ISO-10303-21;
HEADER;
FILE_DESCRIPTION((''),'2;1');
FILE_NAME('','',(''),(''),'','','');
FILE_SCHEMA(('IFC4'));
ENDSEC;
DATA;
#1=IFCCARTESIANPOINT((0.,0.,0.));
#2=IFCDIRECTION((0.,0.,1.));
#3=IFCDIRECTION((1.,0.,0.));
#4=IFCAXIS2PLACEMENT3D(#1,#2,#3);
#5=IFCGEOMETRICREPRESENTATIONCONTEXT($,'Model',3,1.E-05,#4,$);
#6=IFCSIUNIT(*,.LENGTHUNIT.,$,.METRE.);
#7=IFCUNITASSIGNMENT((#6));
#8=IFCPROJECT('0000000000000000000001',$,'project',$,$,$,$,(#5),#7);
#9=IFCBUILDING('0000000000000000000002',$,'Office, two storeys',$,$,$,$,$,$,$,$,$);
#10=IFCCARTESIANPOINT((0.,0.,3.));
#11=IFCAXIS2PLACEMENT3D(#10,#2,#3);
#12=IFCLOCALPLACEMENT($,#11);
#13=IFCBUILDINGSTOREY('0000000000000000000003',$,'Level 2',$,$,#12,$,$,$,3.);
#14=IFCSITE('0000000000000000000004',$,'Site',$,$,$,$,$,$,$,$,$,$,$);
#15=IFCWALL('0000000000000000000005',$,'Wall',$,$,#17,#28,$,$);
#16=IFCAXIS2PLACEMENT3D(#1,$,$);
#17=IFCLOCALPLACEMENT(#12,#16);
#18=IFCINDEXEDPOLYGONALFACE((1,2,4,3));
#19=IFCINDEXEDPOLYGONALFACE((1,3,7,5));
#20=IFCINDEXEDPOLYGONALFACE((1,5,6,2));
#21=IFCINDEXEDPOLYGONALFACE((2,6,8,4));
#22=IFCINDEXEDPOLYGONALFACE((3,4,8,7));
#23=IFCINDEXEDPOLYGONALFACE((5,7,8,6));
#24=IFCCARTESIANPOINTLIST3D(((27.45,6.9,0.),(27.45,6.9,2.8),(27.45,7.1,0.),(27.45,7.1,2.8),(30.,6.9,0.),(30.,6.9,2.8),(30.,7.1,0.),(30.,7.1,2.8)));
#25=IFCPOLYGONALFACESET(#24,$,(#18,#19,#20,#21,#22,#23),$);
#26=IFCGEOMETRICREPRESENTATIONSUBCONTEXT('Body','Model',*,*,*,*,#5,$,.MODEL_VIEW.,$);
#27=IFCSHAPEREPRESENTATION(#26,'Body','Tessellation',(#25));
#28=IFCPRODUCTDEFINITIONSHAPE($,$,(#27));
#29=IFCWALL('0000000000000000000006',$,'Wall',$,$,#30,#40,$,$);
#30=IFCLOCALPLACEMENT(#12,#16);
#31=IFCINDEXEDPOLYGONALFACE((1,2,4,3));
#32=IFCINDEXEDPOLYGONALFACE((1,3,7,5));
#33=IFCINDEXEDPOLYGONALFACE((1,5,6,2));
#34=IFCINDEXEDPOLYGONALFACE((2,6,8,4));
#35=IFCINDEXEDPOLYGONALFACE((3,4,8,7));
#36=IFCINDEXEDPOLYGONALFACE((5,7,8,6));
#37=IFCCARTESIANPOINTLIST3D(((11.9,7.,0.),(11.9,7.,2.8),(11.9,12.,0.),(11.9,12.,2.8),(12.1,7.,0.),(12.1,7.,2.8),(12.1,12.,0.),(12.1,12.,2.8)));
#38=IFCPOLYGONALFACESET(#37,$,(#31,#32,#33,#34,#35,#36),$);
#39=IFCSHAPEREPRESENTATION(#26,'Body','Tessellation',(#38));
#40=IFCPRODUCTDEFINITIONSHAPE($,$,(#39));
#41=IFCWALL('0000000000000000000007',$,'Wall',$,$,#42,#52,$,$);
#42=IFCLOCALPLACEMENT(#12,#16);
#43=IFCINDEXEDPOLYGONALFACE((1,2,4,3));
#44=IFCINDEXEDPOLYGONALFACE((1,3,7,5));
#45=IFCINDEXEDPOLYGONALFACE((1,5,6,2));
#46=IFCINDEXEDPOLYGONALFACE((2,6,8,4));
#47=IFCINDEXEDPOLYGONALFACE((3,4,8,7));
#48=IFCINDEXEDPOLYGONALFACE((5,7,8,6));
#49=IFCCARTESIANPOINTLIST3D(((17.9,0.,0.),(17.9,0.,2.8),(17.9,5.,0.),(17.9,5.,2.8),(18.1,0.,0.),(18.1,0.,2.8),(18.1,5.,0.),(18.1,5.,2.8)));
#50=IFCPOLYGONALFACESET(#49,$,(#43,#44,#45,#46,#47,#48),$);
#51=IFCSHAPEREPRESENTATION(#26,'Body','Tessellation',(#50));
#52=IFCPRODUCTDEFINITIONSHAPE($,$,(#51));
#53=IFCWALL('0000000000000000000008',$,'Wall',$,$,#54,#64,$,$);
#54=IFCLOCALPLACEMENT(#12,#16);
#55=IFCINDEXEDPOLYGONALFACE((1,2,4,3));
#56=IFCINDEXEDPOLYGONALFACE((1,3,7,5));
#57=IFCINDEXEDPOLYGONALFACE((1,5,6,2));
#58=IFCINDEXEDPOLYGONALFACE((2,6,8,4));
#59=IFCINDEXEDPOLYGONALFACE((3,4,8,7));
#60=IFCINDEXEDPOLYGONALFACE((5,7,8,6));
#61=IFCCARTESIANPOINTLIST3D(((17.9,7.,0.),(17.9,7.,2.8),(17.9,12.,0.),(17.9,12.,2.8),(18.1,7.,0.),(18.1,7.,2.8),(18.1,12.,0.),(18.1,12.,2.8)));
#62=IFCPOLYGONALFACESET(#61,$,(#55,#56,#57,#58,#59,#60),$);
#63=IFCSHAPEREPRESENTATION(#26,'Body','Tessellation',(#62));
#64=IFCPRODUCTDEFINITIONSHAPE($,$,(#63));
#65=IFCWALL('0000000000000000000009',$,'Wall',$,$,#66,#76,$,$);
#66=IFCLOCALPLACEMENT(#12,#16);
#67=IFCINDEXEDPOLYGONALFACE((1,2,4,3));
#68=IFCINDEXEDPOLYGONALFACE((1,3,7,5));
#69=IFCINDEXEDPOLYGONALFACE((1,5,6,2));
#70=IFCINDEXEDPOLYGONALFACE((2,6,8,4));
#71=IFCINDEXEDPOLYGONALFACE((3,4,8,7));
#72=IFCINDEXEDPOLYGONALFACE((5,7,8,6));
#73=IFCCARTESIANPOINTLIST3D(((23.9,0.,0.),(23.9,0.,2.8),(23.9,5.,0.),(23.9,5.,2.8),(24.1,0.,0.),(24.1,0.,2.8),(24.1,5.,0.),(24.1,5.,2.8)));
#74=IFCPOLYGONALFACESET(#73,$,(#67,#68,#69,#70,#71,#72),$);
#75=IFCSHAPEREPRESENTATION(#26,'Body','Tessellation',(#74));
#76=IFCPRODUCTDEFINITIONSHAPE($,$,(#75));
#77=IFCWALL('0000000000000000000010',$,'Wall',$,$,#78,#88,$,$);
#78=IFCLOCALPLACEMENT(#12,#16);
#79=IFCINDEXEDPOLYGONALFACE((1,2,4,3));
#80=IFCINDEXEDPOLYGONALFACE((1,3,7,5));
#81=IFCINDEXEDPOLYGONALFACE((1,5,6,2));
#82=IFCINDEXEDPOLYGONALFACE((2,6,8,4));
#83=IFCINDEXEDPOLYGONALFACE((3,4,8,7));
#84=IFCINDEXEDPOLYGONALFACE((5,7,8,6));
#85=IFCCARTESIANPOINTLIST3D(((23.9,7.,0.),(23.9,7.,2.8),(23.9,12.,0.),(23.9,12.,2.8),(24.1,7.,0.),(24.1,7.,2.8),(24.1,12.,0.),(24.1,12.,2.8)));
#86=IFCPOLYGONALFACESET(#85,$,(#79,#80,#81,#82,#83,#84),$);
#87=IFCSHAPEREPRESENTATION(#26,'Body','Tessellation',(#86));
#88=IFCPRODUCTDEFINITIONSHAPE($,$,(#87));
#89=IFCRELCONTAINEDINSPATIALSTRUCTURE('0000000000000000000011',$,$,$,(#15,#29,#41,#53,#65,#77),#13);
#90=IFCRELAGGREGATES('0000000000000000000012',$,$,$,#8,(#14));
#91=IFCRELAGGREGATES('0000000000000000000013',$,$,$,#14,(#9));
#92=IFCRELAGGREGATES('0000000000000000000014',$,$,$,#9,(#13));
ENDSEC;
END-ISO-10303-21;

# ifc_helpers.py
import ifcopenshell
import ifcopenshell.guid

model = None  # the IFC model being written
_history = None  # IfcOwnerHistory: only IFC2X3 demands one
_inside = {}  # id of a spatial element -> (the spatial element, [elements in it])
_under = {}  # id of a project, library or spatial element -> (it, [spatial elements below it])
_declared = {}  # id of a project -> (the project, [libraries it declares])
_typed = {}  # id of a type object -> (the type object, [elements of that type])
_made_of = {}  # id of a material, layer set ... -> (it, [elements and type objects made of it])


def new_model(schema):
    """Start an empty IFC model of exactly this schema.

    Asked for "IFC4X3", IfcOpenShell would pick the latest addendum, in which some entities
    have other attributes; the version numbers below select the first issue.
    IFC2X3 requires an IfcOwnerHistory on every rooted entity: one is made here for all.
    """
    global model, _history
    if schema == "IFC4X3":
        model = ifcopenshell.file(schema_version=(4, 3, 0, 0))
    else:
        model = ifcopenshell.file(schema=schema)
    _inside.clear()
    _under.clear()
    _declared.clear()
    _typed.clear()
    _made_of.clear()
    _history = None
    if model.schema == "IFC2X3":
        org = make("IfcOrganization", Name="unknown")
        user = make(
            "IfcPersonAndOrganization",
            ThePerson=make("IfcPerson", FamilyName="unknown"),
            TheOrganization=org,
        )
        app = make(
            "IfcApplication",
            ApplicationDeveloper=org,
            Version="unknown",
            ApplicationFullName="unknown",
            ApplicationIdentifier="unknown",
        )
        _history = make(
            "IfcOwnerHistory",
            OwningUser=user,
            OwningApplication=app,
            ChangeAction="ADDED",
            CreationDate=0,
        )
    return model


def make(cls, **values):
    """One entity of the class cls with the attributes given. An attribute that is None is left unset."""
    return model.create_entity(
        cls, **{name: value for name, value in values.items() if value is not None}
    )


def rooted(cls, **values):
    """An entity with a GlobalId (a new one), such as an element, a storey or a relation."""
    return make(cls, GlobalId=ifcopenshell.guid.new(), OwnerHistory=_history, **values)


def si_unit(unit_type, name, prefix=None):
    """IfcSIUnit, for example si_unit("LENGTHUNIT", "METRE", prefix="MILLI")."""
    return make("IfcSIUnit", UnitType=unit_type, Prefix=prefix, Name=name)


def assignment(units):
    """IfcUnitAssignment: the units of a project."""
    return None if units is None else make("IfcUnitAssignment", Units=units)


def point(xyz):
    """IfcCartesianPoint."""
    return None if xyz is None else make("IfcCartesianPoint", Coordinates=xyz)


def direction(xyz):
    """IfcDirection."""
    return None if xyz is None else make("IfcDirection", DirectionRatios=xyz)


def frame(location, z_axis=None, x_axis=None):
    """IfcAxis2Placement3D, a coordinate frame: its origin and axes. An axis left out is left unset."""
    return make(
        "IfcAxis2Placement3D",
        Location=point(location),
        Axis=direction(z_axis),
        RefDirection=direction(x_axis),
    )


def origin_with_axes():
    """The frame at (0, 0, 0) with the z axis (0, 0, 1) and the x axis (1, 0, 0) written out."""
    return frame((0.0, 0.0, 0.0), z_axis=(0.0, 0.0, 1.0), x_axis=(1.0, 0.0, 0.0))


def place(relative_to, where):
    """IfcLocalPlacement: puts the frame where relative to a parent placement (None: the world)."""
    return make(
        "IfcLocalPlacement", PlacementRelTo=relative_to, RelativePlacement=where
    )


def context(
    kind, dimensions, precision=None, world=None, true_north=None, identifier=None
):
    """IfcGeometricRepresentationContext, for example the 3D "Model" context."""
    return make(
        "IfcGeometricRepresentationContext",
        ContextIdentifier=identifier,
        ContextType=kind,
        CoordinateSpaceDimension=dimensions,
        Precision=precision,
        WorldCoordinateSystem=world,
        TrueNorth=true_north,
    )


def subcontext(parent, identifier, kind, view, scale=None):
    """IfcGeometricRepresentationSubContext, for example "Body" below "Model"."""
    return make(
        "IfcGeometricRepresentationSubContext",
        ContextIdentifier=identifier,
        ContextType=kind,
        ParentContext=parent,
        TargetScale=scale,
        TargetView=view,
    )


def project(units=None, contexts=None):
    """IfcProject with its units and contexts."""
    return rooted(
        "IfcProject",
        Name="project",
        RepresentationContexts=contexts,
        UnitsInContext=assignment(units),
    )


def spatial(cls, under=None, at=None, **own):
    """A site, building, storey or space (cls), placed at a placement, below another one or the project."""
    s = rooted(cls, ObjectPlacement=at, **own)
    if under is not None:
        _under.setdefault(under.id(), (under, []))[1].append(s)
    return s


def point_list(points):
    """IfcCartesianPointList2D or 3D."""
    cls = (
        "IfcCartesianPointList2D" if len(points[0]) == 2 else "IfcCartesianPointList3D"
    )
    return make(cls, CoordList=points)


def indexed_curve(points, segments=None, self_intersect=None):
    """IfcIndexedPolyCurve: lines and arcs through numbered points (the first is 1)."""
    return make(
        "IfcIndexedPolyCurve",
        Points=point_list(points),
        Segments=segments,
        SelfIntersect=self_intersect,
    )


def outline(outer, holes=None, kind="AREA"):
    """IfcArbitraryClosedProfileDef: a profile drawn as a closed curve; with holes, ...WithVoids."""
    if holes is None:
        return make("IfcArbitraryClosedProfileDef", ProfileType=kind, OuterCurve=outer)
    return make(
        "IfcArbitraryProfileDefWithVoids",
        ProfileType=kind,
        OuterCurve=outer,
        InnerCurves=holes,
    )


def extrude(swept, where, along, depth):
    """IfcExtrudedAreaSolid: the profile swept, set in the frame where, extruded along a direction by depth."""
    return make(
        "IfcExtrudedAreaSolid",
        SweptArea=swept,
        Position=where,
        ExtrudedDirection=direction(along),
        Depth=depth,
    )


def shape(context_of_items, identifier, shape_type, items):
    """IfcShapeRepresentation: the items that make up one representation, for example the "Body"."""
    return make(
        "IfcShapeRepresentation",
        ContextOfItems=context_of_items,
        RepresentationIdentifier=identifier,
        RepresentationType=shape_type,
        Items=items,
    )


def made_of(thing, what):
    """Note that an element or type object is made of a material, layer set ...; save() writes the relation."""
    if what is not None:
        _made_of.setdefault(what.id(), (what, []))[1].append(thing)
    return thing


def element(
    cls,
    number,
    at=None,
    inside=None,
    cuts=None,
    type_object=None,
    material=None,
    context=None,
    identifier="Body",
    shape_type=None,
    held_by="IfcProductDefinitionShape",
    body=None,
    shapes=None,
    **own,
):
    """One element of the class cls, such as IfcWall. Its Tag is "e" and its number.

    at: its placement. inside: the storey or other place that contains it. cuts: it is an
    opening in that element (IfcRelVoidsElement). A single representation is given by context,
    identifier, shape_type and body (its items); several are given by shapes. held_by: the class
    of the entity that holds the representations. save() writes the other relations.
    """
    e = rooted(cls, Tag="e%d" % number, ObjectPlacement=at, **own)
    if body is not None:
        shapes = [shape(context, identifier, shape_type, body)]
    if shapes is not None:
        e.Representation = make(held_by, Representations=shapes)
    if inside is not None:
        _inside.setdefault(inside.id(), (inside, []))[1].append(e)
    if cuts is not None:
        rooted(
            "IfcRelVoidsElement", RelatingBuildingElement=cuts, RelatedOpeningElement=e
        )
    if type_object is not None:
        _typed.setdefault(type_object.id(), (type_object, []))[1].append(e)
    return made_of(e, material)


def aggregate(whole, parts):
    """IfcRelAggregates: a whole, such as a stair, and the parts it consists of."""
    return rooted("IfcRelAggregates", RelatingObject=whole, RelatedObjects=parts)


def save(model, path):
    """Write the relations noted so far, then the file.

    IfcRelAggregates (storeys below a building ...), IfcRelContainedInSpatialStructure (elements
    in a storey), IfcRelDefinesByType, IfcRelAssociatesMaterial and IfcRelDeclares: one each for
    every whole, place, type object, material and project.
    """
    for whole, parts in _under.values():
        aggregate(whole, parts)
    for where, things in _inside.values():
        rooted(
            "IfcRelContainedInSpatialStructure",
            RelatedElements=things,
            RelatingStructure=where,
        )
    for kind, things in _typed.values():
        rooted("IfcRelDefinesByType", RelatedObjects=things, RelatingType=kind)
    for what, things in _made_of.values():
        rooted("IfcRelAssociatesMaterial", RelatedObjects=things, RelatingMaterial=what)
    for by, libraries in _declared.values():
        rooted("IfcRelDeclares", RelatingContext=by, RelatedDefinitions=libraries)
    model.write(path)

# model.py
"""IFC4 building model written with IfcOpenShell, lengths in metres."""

from ifc_helpers import new_model, si_unit, frame, origin_with_axes, place, context, subcontext, project, spatial, indexed_curve, outline, extrude, element, save


model = new_model("IFC4")

# Units and contexts
model_context = context("Model", 3, precision=1e-05, world=origin_with_axes())
body_context = subcontext(model_context, "Body", "Model", "MODEL_VIEW")
ifc_project = project(units=[si_unit("LENGTHUNIT", "METRE")], contexts=[model_context])

# Site, building, storey
site = spatial("IfcSite", under=ifc_project, Name="Site")
building = spatial("IfcBuilding", under=site, Name="Office, two storeys")
storey_placement = place(None, frame((0.0, 0.0, 3.0), z_axis=(0.0, 0.0, 1.0), x_axis=(1.0, 0.0, 0.0)))
storey = spatial("IfcBuildingStorey", under=building, at=storey_placement, Name="Level 2", Elevation=3.0)

# Walls
wall_1_placement = place(storey_placement, frame((27.45, 7.0, 0.0), z_axis=(0.0, 0.0, 1.0), x_axis=(1.0, 0.0, 0.0)))
element("IfcWall", 1, at=wall_1_placement, inside=storey, Name="Wall", context=body_context, shape_type="SweptSolid", body=[
    extrude(outline(indexed_curve([(0.0, 0.0), (0.0, 0.2), (2.55, 0.2), (2.55, 0.0), (0.0, 0.0)], self_intersect=False)), frame((0.0, -0.1, 0.0), z_axis=(0.0, 0.0, 1.0), x_axis=(1.0, 0.0, 0.0)), (0.0, 0.0, 1.0), 2.8),
])
for number, where, z_axis, x_axis, name in (
    (2, (12.0, 7.0, 0.0), (0.0, 0.0, 1.0), (0.0, 1.0, 0.0), "Wall"),
    (3, (18.0, 0.0, 0.0), (0.0, 0.0, 1.0), (0.0, 1.0, 0.0), "Wall"),
    (4, (18.0, 7.0, 0.0), (0.0, 0.0, 1.0), (0.0, 1.0, 0.0), "Wall"),
    (5, (24.0, 0.0, 0.0), (0.0, 0.0, 1.0), (0.0, 1.0, 0.0), "Wall"),
    (6, (24.0, 7.0, 0.0), (0.0, 0.0, 1.0), (0.0, 1.0, 0.0), "Wall"),
):
    element("IfcWall", number, at=place(storey_placement, frame(where, z_axis=z_axis, x_axis=x_axis)), inside=storey, Name=name, context=body_context, shape_type="SweptSolid", body=[
        extrude(outline(indexed_curve([(0.0, 0.0), (0.0, 0.2), (5.0, 0.2), (5.0, 0.0), (0.0, 0.0)], self_intersect=False)), frame((0.0, -0.1, 0.0), z_axis=(0.0, 0.0, 1.0), x_axis=(1.0, 0.0, 0.0)), (0.0, 0.0, 1.0), 2.8),
    ])

save(model, "model.ifc")
